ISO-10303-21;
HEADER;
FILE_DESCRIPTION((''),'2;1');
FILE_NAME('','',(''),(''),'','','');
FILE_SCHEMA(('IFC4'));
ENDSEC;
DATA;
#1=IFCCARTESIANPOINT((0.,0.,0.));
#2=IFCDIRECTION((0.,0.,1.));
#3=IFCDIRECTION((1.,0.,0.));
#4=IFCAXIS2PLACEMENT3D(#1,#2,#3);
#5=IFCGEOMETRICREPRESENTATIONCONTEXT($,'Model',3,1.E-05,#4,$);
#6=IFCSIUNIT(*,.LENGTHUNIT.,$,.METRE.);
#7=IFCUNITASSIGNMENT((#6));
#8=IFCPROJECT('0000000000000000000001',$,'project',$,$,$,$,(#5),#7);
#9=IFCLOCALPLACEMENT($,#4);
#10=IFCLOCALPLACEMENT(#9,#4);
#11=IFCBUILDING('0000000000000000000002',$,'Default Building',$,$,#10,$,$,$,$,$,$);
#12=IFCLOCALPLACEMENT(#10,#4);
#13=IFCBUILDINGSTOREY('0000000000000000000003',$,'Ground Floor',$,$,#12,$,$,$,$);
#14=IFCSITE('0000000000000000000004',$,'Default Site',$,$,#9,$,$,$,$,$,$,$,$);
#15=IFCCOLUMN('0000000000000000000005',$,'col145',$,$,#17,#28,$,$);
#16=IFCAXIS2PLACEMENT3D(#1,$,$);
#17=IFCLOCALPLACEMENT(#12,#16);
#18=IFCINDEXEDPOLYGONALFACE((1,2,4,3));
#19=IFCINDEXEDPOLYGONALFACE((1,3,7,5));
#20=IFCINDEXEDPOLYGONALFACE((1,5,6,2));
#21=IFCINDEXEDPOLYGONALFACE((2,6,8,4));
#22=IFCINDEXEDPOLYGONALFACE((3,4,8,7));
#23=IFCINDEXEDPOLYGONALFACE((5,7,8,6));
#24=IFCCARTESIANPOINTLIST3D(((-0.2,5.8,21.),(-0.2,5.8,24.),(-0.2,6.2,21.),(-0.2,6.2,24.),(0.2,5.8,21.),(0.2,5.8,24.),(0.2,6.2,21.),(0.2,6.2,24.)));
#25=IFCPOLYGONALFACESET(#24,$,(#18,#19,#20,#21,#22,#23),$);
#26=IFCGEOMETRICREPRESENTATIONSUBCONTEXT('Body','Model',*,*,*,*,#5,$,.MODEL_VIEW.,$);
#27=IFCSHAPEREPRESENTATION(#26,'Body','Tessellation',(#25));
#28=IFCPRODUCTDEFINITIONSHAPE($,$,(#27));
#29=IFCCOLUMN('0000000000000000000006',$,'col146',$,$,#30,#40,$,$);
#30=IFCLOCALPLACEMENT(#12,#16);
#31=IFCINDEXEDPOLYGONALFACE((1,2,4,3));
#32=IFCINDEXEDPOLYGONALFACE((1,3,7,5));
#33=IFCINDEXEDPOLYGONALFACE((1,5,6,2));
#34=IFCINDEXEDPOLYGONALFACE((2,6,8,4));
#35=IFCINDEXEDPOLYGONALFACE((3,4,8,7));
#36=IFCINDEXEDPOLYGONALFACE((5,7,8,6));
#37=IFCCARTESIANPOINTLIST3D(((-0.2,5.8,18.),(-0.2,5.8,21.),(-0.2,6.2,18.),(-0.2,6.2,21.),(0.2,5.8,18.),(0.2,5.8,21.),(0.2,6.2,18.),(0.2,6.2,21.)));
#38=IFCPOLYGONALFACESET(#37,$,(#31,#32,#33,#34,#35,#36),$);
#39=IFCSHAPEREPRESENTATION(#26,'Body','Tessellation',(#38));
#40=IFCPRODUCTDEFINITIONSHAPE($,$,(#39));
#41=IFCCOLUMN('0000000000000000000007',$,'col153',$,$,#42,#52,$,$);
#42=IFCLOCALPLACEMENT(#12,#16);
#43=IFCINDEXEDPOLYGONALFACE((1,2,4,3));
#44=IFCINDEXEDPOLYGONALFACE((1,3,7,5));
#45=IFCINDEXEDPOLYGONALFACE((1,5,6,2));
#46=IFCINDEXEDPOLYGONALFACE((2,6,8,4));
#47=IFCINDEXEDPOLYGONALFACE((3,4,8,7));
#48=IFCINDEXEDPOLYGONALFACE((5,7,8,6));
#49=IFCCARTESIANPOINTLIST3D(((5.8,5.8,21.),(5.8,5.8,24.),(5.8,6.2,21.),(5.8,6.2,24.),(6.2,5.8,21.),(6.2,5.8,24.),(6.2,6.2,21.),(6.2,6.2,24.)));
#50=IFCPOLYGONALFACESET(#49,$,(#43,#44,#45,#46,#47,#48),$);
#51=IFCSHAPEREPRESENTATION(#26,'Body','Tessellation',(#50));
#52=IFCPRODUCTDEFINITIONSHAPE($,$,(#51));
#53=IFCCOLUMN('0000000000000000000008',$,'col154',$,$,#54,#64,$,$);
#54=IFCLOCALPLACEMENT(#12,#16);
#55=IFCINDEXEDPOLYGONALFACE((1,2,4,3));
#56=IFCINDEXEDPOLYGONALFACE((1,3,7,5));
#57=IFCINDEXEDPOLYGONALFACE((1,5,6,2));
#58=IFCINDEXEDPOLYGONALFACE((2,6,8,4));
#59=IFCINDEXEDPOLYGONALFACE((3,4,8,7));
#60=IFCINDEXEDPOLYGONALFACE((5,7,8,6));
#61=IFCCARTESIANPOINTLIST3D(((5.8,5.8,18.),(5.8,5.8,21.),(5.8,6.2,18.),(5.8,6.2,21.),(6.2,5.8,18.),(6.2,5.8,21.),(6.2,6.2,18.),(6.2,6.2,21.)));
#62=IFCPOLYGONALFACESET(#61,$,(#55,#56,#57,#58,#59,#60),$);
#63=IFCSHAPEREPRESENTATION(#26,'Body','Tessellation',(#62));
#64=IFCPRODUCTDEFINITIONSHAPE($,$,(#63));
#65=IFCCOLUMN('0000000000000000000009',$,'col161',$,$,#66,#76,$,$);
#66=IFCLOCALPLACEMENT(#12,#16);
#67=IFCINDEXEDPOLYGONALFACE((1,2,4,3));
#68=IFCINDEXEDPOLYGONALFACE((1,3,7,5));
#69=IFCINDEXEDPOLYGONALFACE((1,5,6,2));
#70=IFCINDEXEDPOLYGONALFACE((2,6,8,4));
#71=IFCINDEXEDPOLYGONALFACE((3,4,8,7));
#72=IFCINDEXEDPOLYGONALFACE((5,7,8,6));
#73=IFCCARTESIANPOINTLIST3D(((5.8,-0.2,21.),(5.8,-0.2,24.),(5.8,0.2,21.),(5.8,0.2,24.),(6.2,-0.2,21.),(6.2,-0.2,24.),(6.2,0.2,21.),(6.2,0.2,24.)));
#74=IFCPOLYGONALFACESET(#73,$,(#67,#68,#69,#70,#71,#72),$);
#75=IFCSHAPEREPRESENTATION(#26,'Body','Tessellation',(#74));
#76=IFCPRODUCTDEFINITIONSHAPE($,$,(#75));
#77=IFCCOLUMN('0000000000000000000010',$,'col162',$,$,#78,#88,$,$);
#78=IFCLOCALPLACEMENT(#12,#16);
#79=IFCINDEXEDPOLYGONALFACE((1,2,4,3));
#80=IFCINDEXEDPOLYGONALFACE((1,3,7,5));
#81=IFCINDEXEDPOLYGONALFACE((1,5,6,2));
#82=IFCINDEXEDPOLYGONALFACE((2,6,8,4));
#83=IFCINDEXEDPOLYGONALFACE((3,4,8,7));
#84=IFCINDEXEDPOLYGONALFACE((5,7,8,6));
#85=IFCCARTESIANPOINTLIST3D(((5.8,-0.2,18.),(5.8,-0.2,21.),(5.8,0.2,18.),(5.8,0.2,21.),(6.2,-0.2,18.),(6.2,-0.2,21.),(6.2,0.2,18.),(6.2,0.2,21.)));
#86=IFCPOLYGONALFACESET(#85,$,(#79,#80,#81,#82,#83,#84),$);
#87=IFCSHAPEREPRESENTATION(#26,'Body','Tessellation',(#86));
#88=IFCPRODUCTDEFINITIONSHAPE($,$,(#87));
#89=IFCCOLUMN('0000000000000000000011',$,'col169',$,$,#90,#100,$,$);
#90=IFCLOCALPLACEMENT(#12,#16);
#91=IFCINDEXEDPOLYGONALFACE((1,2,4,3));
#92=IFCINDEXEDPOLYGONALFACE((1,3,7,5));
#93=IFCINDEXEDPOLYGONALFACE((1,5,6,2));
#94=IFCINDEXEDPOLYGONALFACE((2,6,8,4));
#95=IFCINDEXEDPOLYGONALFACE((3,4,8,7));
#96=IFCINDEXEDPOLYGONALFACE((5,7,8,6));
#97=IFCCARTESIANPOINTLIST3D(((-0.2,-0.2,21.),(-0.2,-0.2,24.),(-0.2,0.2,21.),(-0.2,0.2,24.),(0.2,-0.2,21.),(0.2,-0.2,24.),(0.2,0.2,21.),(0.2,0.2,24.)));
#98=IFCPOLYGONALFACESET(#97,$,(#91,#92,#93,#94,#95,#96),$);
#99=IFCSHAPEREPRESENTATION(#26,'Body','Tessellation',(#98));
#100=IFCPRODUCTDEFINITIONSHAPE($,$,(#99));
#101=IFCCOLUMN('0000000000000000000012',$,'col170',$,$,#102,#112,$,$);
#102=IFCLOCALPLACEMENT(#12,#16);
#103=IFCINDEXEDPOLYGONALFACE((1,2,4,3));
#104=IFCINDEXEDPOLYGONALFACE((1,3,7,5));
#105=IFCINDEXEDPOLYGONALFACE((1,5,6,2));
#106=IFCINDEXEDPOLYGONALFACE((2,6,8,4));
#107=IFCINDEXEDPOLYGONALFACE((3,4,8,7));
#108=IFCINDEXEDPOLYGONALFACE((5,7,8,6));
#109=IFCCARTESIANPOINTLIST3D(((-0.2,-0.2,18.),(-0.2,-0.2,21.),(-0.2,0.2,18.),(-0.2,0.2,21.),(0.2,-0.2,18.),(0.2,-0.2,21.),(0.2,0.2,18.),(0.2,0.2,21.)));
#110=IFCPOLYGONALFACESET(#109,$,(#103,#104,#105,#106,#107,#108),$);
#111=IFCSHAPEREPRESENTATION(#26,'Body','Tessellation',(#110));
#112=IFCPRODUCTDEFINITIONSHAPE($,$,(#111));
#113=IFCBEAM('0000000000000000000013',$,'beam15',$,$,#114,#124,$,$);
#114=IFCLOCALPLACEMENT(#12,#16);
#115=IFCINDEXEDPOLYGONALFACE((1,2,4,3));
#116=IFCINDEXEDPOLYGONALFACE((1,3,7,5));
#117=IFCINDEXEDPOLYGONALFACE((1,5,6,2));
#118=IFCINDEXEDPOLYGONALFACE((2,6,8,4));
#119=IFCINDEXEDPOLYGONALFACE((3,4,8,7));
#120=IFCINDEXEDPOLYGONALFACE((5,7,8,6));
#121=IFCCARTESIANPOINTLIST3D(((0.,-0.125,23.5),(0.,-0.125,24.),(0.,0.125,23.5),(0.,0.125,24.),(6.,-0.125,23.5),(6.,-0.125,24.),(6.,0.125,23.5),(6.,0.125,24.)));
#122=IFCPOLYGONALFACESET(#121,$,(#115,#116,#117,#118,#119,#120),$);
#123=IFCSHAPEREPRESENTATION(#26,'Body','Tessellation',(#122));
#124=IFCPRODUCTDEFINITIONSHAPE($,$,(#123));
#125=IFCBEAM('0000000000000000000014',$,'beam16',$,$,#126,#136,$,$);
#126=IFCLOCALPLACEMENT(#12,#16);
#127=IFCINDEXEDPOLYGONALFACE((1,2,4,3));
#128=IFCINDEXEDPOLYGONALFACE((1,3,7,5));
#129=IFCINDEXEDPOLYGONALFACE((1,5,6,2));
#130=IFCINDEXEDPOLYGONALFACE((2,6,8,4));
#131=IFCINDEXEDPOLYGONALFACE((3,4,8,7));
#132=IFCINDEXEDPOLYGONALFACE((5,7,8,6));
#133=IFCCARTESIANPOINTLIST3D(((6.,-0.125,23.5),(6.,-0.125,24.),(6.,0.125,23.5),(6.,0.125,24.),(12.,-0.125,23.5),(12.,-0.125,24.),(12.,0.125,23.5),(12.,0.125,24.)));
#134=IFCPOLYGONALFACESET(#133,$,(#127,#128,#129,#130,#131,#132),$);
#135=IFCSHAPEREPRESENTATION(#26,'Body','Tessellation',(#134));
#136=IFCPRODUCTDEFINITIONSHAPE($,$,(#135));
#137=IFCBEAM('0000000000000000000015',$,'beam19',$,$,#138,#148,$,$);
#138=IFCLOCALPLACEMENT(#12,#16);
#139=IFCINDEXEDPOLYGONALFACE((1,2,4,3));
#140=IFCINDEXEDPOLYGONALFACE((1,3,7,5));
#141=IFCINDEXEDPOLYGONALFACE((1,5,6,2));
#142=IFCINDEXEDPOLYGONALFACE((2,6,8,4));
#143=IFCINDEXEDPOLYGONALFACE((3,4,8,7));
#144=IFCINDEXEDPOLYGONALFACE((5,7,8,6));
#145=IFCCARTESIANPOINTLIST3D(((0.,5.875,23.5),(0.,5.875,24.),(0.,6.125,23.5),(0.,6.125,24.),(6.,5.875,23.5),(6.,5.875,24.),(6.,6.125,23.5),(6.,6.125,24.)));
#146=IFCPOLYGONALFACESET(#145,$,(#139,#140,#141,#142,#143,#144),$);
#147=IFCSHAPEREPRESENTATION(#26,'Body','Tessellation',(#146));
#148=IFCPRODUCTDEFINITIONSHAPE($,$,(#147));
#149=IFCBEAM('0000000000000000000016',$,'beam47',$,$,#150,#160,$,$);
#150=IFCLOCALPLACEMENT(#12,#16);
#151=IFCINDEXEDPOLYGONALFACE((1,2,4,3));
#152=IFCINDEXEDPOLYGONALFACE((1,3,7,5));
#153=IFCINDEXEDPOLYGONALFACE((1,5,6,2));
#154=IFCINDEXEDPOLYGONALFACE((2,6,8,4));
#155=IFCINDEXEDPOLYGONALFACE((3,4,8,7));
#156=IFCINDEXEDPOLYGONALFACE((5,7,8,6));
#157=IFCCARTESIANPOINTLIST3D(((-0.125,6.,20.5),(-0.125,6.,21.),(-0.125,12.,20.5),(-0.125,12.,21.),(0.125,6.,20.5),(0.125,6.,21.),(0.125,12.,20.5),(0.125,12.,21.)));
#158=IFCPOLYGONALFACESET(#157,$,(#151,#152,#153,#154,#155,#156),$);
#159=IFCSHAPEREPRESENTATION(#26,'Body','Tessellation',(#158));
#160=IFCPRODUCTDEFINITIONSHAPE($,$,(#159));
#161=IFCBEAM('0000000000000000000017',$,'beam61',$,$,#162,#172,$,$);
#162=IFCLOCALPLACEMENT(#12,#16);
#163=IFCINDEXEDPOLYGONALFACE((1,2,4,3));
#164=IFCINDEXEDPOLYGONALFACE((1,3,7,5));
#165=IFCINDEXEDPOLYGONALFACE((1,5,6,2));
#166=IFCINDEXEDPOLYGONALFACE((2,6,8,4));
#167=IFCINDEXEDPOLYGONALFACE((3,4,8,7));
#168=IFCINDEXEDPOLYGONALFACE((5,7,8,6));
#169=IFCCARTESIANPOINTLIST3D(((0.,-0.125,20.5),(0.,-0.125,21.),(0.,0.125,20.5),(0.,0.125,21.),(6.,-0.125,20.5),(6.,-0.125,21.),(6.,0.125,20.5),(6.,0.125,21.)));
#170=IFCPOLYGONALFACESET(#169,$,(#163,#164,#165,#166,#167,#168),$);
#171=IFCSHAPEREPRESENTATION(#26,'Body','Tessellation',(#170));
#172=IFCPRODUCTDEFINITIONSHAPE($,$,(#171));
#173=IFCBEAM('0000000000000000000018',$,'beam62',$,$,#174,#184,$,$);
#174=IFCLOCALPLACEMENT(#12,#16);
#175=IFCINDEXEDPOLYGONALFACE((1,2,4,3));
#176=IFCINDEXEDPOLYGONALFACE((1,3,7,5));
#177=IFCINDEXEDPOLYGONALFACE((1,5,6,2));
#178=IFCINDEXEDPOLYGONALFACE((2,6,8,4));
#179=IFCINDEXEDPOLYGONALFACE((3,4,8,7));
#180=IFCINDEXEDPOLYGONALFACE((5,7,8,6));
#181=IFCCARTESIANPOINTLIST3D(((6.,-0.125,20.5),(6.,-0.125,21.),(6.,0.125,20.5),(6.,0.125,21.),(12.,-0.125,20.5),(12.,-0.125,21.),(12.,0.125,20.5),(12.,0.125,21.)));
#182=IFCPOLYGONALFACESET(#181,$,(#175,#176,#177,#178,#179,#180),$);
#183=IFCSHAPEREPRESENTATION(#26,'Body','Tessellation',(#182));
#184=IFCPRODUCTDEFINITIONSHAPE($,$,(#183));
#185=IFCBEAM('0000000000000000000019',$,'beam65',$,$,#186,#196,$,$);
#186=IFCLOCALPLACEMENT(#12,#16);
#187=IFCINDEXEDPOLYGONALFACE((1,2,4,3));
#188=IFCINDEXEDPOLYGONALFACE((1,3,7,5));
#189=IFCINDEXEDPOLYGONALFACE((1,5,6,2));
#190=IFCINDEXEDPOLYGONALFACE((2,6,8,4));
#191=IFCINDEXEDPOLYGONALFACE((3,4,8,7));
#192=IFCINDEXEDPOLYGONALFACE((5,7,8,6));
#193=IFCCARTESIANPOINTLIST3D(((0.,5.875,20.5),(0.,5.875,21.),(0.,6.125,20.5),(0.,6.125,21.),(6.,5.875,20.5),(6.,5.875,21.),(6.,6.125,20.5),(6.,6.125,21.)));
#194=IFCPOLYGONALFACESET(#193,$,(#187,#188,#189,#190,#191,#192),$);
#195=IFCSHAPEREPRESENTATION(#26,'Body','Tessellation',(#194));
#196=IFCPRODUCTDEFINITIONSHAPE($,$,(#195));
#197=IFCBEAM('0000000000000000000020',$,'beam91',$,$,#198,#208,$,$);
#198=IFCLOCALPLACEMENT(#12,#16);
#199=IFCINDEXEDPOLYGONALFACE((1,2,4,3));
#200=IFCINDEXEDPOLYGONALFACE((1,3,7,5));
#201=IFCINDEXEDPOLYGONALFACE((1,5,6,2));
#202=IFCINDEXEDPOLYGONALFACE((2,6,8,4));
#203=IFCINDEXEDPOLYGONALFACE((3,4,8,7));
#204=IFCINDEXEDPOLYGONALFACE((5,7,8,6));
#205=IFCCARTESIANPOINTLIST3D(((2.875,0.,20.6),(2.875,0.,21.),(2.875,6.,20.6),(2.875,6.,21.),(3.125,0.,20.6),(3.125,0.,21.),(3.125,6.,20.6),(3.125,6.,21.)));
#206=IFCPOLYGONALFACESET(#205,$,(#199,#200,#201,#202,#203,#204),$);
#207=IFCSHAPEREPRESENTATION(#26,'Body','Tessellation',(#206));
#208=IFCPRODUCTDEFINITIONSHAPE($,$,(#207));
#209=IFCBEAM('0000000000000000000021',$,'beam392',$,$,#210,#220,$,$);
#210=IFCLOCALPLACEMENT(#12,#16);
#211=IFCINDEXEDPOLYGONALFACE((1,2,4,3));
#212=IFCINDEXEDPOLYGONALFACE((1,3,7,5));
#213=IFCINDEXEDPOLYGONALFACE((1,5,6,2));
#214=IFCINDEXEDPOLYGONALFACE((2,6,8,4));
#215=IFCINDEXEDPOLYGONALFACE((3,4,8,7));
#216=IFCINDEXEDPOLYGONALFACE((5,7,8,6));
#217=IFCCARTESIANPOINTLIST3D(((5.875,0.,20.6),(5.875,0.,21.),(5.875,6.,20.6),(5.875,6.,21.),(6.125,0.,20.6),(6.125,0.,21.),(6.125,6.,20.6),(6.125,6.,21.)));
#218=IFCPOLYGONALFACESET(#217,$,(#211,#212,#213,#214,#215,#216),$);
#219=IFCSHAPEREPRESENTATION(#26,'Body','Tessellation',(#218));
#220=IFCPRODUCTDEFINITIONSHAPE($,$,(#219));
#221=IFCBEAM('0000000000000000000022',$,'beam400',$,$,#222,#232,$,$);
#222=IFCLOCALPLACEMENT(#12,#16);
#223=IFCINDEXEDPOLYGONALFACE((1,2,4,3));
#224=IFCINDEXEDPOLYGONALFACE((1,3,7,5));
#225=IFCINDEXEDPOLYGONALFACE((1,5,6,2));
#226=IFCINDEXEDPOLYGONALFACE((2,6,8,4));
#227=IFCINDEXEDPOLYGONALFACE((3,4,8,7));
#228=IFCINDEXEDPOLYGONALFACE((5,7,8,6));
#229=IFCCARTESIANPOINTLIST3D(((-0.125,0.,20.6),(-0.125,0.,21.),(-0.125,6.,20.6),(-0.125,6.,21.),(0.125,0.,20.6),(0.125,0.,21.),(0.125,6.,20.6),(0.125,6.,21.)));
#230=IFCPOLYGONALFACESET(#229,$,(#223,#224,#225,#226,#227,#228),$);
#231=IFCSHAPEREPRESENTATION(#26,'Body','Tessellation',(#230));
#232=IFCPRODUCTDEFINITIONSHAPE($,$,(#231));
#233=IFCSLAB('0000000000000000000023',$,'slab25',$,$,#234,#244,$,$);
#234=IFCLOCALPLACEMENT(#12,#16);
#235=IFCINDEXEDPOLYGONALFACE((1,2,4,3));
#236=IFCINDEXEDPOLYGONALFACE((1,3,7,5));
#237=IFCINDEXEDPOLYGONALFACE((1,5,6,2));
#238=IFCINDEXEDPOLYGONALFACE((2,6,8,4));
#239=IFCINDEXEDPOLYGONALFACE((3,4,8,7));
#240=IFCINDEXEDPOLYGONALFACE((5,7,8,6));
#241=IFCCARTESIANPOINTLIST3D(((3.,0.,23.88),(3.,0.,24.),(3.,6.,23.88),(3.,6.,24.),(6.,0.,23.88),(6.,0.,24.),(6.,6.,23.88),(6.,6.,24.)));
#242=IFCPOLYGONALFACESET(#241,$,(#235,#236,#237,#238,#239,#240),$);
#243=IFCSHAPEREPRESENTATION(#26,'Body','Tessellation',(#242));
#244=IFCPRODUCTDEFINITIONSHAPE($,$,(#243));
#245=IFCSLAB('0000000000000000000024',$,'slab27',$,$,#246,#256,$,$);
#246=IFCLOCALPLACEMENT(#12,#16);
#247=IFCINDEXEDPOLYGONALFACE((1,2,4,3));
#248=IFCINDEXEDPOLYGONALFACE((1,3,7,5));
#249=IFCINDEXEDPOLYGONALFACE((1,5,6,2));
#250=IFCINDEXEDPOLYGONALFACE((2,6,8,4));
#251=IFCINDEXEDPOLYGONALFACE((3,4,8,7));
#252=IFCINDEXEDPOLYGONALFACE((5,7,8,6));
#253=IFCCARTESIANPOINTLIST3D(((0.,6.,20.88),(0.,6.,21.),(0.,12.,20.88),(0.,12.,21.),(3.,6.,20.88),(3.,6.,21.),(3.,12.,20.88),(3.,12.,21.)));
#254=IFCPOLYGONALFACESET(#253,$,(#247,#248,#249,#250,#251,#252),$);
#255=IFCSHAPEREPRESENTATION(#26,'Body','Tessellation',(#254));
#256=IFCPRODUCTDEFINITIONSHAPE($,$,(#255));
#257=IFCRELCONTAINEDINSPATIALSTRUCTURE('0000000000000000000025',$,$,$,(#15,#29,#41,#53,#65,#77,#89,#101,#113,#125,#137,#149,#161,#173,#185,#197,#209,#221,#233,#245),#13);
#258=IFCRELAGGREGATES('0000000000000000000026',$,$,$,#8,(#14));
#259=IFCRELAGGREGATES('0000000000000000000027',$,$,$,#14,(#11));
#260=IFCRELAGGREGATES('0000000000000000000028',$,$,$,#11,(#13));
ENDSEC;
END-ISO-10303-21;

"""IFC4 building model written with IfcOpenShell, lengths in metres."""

from ifc_helpers import new_model, si_unit, frame, origin_with_axes, place, context, subcontext, project, spatial, indexed_curve, outline, extrude, element, save


model = new_model("IFC4")

# Units and contexts
model_context = context("Model", 3, precision=1e-05, world=origin_with_axes())
body_context = subcontext(model_context, "Body", "Model", "MODEL_VIEW")
ifc_project = project(units=[si_unit("LENGTHUNIT", "METRE")], contexts=[model_context])

# Site, building, storey
site_placement = place(None, origin_with_axes())
site = spatial("IfcSite", under=ifc_project, at=site_placement, Name="Default Site")
building_placement = place(site_placement, origin_with_axes())
building = spatial("IfcBuilding", under=site, at=building_placement, Name="Default Building")
storey_placement = place(building_placement, origin_with_axes())
storey = spatial("IfcBuildingStorey", under=building, at=storey_placement, Name="Ground Floor")

# Columns
for number, where, z_axis, x_axis, name in (
    (1, (-0.2, 5.8, 21.0), (0.0, 0.0, 1.0), (1.0, 0.0, 0.0), "col145"),
    (2, (-0.2, 5.8, 18.0), (0.0, 0.0, 1.0), (1.0, 0.0, 0.0), "col146"),
    (3, (5.8, 5.8, 21.0), (0.0, 0.0, 1.0), (1.0, 0.0, 0.0), "col153"),
    (4, (5.8, 5.8, 18.0), (0.0, 0.0, 1.0), (1.0, 0.0, 0.0), "col154"),
    (5, (5.8, -0.2, 21.0), (0.0, 0.0, 1.0), (1.0, 0.0, 0.0), "col161"),
    (6, (5.8, -0.2, 18.0), (0.0, 0.0, 1.0), (1.0, 0.0, 0.0), "col162"),
    (7, (-0.2, -0.2, 21.0), (0.0, 0.0, 1.0), (1.0, 0.0, 0.0), "col169"),
    (8, (-0.2, -0.2, 18.0), (0.0, 0.0, 1.0), (1.0, 0.0, 0.0), "col170"),
):
    element("IfcColumn", number, at=place(storey_placement, frame(where, z_axis=z_axis, x_axis=x_axis)), inside=storey, Name=name, context=body_context, shape_type="SweptSolid", body=[
        extrude(outline(indexed_curve([(0.0, 0.0), (0.0, 0.4), (0.4, 0.4), (0.4, 0.0), (0.0, 0.0)], self_intersect=False)), origin_with_axes(), (0.0, 0.0, 1.0), 3.0),
    ])

# Beams
for number, where, z_axis, x_axis, name in (
    (9, (0.0, -0.125, 23.5), (0.0, 0.0, 1.0), (1.0, 0.0, 0.0), "beam15"),
    (10, (6.0, -0.125, 23.5), (0.0, 0.0, 1.0), (1.0, 0.0, 0.0), "beam16"),
    (11, (0.0, 5.875, 23.5), (0.0, 0.0, 1.0), (1.0, 0.0, 0.0), "beam19"),
    (12, (0.125, 6.0, 20.5), (0.0, 0.0, 1.0), (0.0, 1.0, 0.0), "beam47"),
    (13, (0.0, -0.125, 20.5), (0.0, 0.0, 1.0), (1.0, 0.0, 0.0), "beam61"),
    (14, (6.0, -0.125, 20.5), (0.0, 0.0, 1.0), (1.0, 0.0, 0.0), "beam62"),
    (15, (0.0, 5.875, 20.5), (0.0, 0.0, 1.0), (1.0, 0.0, 0.0), "beam65"),
):
    element("IfcBeam", number, at=place(storey_placement, frame(where, z_axis=z_axis, x_axis=x_axis)), inside=storey, Name=name, context=body_context, shape_type="SweptSolid", body=[
        extrude(outline(indexed_curve([(0.0, 0.0), (0.0, 0.25), (6.0, 0.25), (6.0, 0.0), (0.0, 0.0)], self_intersect=False)), origin_with_axes(), (0.0, 0.0, 1.0), 0.5),
    ])
for number, where, z_axis, x_axis, name in (
    (16, (2.875, 6.0, 20.6), (0.0, 0.0, 1.0), (0.0, -1.0, 0.0), "beam91"),
    (17, (5.875, 6.0, 20.6), (0.0, 0.0, 1.0), (0.0, -1.0, 0.0), "beam392"),
    (18, (-0.125, 6.0, 20.6), (0.0, 0.0, 1.0), (0.0, -1.0, 0.0), "beam400"),
):
    element("IfcBeam", number, at=place(storey_placement, frame(where, z_axis=z_axis, x_axis=x_axis)), inside=storey, Name=name, context=body_context, shape_type="SweptSolid", body=[
        extrude(outline(indexed_curve([(0.0, 0.0), (0.0, 0.25), (6.0, 0.25), (6.0, 0.0), (0.0, 0.0)], self_intersect=False)), origin_with_axes(), (0.0, 0.0, 1.0), 0.4),
    ])

# Slabs
for number, where, z_axis, x_axis, name in (
    (19, (3.0, 0.0, 23.88), (0.0, 0.0, 1.0), (1.0, 0.0, 0.0), "slab25"),
    (20, (0.0, 6.0, 20.88), (0.0, 0.0, 1.0), (1.0, 0.0, 0.0), "slab27"),
):
    element("IfcSlab", number, at=place(storey_placement, frame(where, z_axis=z_axis, x_axis=x_axis)), inside=storey, Name=name, context=body_context, shape_type="SweptSolid", body=[
        extrude(outline(indexed_curve([(0.0, 0.0), (0.0, 6.0), (3.0, 6.0), (3.0, 0.0), (0.0, 0.0)], self_intersect=False)), origin_with_axes(), (0.0, 0.0, 1.0), 0.12),
    ])

save(model, "model.ifc")
